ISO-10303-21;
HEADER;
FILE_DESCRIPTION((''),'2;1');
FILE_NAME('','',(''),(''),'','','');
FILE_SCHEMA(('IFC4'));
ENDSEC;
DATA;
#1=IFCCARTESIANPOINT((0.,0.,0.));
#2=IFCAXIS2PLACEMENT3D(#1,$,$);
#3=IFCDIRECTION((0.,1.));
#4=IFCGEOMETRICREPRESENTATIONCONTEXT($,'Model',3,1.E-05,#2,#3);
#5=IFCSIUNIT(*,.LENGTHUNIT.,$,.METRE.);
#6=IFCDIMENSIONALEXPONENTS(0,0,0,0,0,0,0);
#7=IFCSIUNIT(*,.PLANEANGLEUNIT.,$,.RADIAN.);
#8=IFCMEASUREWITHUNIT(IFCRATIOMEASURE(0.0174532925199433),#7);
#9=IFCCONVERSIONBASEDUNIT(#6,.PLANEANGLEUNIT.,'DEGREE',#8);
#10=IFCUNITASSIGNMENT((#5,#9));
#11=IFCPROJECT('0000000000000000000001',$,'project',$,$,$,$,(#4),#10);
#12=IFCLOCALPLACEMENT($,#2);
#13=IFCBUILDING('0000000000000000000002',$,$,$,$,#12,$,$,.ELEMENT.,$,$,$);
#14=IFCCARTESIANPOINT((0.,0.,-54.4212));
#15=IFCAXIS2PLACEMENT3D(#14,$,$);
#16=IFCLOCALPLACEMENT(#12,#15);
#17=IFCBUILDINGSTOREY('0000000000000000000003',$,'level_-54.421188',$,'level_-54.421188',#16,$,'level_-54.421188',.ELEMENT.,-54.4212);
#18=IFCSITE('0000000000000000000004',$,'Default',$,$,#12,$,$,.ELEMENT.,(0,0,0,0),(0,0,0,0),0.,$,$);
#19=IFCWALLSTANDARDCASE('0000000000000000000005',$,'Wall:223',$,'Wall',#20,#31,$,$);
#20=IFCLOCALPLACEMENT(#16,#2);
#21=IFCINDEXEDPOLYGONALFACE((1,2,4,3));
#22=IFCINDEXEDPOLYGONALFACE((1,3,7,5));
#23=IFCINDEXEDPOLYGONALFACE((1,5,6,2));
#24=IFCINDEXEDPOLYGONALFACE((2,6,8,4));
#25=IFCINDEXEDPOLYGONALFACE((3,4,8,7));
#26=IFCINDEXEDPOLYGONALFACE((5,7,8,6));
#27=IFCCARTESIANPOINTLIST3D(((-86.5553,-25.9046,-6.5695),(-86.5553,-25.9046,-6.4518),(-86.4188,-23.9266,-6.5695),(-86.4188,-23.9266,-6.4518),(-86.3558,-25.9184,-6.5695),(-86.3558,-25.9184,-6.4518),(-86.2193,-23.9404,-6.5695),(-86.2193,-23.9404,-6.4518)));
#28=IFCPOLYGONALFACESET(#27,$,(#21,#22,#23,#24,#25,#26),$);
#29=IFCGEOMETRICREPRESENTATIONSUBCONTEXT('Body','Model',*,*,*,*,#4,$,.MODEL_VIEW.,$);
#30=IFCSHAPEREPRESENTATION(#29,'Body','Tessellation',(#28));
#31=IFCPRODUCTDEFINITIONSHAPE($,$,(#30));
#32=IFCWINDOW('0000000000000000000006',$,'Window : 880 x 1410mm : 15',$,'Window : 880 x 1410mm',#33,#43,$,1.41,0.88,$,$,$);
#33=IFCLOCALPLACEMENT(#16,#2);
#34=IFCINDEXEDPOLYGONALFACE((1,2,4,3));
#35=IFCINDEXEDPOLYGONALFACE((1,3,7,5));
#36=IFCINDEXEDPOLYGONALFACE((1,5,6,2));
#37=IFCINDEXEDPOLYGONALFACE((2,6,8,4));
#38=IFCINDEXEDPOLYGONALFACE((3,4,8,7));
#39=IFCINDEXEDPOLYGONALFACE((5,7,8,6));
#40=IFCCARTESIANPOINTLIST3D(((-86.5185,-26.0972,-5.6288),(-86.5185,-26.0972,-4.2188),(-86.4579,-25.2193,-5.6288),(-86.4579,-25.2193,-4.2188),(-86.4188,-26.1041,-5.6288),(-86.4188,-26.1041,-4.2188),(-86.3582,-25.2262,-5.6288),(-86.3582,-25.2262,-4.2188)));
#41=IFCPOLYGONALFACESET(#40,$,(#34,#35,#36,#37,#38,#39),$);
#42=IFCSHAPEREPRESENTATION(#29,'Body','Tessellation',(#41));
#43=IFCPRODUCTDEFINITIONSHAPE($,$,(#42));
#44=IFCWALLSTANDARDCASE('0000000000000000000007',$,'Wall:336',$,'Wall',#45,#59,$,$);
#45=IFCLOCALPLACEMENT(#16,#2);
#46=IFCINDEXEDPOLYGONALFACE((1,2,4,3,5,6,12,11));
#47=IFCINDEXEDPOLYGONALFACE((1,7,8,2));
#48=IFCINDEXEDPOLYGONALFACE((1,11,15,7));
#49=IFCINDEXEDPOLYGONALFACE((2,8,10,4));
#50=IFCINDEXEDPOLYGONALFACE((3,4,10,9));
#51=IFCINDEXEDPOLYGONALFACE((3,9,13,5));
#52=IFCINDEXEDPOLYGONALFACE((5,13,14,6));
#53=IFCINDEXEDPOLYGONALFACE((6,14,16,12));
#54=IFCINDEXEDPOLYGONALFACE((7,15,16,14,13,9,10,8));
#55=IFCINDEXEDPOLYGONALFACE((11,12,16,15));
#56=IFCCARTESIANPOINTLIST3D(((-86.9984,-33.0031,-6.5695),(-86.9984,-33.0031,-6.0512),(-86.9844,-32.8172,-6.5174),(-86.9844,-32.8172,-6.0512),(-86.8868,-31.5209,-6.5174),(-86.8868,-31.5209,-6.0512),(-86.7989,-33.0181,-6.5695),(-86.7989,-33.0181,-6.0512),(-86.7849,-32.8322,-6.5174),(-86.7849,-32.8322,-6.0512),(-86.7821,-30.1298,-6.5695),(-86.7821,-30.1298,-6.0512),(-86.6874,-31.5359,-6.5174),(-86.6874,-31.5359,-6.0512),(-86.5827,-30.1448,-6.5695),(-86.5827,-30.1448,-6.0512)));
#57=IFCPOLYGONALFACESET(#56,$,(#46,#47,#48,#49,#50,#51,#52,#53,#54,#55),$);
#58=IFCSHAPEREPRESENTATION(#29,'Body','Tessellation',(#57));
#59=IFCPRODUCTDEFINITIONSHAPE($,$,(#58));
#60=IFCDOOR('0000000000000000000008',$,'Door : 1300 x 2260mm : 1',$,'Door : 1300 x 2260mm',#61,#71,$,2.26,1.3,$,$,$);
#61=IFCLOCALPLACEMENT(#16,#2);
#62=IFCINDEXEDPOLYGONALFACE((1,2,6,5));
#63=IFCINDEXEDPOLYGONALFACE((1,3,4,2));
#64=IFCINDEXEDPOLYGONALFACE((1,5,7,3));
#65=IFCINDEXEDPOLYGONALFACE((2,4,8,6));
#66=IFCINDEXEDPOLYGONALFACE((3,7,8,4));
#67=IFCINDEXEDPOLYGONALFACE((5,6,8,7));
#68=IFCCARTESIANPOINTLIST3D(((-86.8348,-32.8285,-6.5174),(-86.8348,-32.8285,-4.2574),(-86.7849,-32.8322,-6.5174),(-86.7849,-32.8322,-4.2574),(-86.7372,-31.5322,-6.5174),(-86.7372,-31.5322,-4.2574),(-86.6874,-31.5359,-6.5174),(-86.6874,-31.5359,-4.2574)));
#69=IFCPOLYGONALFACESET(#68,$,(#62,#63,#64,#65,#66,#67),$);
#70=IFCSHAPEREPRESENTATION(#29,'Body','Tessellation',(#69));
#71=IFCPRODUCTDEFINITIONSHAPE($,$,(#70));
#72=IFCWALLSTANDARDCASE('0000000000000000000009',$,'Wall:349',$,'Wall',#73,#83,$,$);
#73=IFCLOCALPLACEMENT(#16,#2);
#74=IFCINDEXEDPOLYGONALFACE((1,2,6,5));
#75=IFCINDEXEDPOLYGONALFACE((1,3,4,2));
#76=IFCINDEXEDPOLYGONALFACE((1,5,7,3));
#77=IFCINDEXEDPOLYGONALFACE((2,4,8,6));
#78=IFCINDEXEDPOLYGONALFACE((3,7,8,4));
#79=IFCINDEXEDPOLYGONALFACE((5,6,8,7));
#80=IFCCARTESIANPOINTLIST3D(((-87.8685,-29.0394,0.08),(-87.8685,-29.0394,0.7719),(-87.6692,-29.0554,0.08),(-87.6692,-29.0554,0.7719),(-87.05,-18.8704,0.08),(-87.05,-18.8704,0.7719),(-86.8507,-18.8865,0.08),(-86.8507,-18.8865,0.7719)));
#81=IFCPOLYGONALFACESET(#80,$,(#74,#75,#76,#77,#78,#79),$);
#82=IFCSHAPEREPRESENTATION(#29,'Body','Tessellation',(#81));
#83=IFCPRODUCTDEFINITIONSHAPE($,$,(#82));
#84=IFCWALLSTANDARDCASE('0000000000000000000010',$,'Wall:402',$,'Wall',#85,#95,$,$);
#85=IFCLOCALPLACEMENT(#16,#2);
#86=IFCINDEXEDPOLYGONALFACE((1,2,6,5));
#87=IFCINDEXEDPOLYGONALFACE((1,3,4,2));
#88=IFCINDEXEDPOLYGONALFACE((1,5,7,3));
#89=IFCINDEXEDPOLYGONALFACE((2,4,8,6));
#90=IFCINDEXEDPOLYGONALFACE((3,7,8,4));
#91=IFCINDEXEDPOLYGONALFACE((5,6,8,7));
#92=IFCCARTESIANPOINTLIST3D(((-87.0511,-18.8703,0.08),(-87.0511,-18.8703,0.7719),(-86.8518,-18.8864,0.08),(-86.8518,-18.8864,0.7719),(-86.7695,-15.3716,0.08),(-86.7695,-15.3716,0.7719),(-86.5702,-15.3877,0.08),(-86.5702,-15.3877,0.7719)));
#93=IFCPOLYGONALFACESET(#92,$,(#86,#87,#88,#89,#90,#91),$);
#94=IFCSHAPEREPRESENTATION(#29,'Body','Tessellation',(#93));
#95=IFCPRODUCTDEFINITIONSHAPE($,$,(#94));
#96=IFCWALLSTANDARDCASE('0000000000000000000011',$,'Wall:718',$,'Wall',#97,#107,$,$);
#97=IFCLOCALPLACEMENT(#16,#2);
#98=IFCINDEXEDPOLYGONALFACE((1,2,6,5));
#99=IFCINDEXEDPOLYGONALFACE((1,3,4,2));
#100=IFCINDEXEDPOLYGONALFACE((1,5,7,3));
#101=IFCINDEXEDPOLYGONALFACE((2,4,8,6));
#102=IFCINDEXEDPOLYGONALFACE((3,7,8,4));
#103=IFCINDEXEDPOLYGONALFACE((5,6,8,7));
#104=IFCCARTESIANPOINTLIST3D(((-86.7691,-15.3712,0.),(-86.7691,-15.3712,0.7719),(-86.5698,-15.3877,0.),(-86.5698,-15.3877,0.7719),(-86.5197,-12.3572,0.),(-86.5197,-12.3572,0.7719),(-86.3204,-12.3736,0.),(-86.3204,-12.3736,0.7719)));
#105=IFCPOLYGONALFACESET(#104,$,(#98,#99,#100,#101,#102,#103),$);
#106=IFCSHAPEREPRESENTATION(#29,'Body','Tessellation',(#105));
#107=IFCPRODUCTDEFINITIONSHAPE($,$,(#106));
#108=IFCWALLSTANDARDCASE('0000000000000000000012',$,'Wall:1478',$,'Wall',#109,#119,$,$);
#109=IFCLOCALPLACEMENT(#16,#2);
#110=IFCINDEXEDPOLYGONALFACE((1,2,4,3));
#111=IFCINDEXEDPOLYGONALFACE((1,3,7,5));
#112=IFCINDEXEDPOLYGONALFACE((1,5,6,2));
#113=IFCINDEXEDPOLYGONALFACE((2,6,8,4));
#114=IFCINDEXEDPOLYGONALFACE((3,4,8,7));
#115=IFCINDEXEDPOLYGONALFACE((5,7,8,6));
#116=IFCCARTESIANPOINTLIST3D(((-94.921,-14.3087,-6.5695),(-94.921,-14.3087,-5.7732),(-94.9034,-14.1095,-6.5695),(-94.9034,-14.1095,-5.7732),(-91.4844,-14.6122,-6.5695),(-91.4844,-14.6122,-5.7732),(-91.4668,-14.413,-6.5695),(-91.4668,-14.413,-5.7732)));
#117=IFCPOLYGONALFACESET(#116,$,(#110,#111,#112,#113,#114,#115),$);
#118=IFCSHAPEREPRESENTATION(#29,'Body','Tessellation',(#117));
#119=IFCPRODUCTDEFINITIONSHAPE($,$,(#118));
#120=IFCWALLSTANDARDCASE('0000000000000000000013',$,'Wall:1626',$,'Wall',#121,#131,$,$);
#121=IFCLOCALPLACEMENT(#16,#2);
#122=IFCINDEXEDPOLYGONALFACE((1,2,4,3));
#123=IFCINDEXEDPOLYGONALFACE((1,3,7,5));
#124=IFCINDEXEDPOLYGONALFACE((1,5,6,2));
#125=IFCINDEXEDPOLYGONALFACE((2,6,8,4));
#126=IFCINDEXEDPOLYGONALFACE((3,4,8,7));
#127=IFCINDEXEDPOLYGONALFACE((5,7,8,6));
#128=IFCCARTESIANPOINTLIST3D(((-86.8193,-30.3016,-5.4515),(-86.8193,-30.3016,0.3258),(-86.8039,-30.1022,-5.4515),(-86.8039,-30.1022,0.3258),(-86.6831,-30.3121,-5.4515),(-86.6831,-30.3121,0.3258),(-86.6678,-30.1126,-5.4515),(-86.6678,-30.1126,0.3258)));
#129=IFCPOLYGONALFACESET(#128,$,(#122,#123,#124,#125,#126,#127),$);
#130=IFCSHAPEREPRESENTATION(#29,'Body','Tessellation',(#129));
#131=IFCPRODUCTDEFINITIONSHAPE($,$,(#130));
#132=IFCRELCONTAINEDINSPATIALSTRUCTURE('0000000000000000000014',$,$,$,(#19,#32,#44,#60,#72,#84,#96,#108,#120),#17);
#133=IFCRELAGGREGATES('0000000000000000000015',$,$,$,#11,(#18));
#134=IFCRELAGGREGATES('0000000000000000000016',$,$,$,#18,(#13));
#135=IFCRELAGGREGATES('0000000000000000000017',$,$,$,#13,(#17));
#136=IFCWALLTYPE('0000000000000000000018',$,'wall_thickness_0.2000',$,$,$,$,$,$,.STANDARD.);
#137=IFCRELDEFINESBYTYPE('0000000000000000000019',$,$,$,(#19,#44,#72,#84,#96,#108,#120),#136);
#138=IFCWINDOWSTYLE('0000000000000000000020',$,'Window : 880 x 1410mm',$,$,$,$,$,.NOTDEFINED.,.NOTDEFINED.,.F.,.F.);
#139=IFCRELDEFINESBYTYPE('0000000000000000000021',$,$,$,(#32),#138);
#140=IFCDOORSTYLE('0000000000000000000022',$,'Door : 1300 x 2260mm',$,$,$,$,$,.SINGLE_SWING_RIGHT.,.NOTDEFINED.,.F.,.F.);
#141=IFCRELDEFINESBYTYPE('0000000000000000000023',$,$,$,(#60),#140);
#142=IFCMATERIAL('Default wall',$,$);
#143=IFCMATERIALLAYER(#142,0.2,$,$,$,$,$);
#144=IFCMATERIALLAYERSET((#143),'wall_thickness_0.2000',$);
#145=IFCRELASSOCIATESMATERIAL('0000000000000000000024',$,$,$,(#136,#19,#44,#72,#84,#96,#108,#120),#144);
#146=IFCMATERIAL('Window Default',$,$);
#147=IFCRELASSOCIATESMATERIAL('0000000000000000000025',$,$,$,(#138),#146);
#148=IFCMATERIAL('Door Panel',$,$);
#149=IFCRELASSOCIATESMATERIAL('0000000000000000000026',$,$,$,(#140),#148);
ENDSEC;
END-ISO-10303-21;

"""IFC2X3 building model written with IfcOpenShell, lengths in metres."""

from ifc_helpers import new_model, entity, si_unit, converted_unit, direction, frame, frame_2d, origin, origin_2d_with_axis, place, context, subcontext, project, spatial, polyline, rectangle, outline, extrude, source, transform, mapped, material, layer, layer_set, layer_usage, type_object, type_shapes, element, fill, save


model = new_model("IFC2X3")

# Units and contexts
model_context = context("Model", 3, precision=1e-05, world=origin(), true_north=direction((0.0, 1.0)))
body_context = subcontext(model_context, "Body", "Model", "MODEL_VIEW")
ifc_project = project(units=[si_unit("LENGTHUNIT", "METRE"), converted_unit("PLANEANGLEUNIT", "DEGREE", entity("IfcRatioMeasure", 0.0174532925199433), si_unit("PLANEANGLEUNIT", "RADIAN"), dimensions=[0, 0, 0, 0, 0, 0, 0])], contexts=[model_context])

# Site, building, storey
placement_1 = place(None, origin())
site = spatial("IfcSite", under=ifc_project, at=placement_1, Name="Default", CompositionType="ELEMENT", RefLatitude=(0, 0, 0, 0), RefLongitude=(0, 0, 0, 0), RefElevation=0.0)
building = spatial("IfcBuilding", under=site, at=placement_1, CompositionType="ELEMENT")
storey_placement = place(placement_1, frame((0.0, 0.0, -54.4212)))
storey = spatial("IfcBuildingStorey", under=building, at=storey_placement, Name="level_-54.421188", ObjectType="level_-54.421188", LongName="level_-54.421188", CompositionType="ELEMENT", Elevation=-54.4212)

# Wall, opening, window
ifc_material_1 = material(Name="Default wall")
ifc_layer = layer(ifc_material_1, 0.2)
ifc_layer_set = layer_set([ifc_layer], Name="wall_thickness_0.2000")
ifc_layer_usage = layer_usage(ifc_layer_set, "AXIS2", "POSITIVE", -0.1)
wall_type = type_object("IfcWallType", Name="wall_thickness_0.2000", PredefinedType="STANDARD", material=ifc_layer_set)
placement_2 = place(placement_1, frame((0.0, 0.0, -60.9907)))
wall_1_placement = place(placement_2, frame((-86.319, -23.9335, 0.0), z_axis=(0.0, 0.0, 1.0), x_axis=(-0.068864, -0.997626, 0.0)))
wall_1 = element("IfcWallStandardCase", 1, at=wall_1_placement, inside=storey, type_object=wall_type, material=ifc_layer_usage, Name="Wall:223", ObjectType="Wall", context=body_context, shape_type="SweptSolid", body=[
    extrude(outline(polyline([(1.9827, -0.1), (1.9827, 0.1), (0.0, 0.1), (0.0, -0.1), (1.9827, -0.1)])), origin(), (0.0, 0.0, 1.0), 0.1176),
])
opening_1_placement = place(wall_1_placement, frame((1.2923, -0.1, 0.9407)))
opening_1 = element("IfcOpeningElement", 2, at=opening_1_placement, cuts=wall_1, ObjectType="Opening", context=body_context, shape_type="SweptSolid", body=[
    extrude(rectangle(XDim=0.88, YDim=1.41, at=frame_2d((0.705, 0.44), x_axis=(0.0, 1.0))), frame((0.0, 0.0, 0.0), z_axis=(0.0, 1.0, 0.0), x_axis=(0.0, 0.0, 1.0)), (0.0, 0.0, 1.0), 0.2),
])
ifc_material_2 = material(Name="Window Default")
window_style_1 = type_object("IfcWindowStyle", Name="Window : 880 x 1410mm", ConstructionType="NOTDEFINED", OperationType="NOTDEFINED", ParameterTakesPrecedence=False, Sizeable=False, material=ifc_material_2)
shared_shape_1 = source(origin(), body_context, "Body", "SweptSolid", [
    extrude(rectangle(XDim=0.1, YDim=0.88, at=origin_2d_with_axis()), frame((0.44, 0.1, 0.0), z_axis=(0.0, 0.0, 1.0), x_axis=(0.0, 1.0, 0.0)), (0.0, 0.0, 1.0), 1.41),
])
type_shapes(window_style_1, [shared_shape_1])
window_1_placement = place(opening_1_placement, origin())
window_1 = element("IfcWindow", 3, at=window_1_placement, inside=storey, type_object=window_style_1, Name="Window : 880 x 1410mm : 15", ObjectType="Window : 880 x 1410mm", OverallHeight=1.41, OverallWidth=0.88, context=body_context, shape_type="MappedRepresentation", body=[
    mapped(shared_shape_1, transform((0.0, 0.0, 0.0), scale=1.0)),
])
fill(opening_1, window_1)

# Wall, opening, door
placement_3 = place(placement_1, frame((0.0, 0.0, -60.9907)))
wall_2_placement = place(placement_3, frame((-86.6824, -30.1373, 0.0), z_axis=(0.0, 0.0, 1.0), x_axis=(-0.075052, -0.99718, 0.0)))
wall_2 = element("IfcWallStandardCase", 4, at=wall_2_placement, inside=storey, type_object=wall_type, material=ifc_layer_usage, Name="Wall:336", ObjectType="Wall", context=body_context, shape_type="SweptSolid", body=[
    extrude(outline(polyline([(2.8814, -0.1), (2.8814, 0.1), (0.0, 0.1), (0.0, -0.1), (2.8814, -0.1)])), origin(), (0.0, 0.0, 1.0), 0.5182),
])
opening_2_placement = place(wall_2_placement, frame((1.395, -0.1, 0.052)))
opening_2 = element("IfcOpeningElement", 5, at=opening_2_placement, cuts=wall_2, ObjectType="Opening", context=body_context, shape_type="SweptSolid", body=[
    extrude(rectangle(XDim=1.3, YDim=2.26, at=frame_2d((1.13, 0.65), x_axis=(0.0, 1.0))), frame((0.0, 0.0, 0.0), z_axis=(0.0, 1.0, 0.0), x_axis=(0.0, 0.0, 1.0)), (0.0, 0.0, 1.0), 0.2),
])
ifc_material_3 = material(Name="Door Panel")
door_style = type_object("IfcDoorStyle", Name="Door : 1300 x 2260mm", ConstructionType="NOTDEFINED", OperationType="SINGLE_SWING_RIGHT", ParameterTakesPrecedence=False, Sizeable=False, material=ifc_material_3)
shared_shape_2 = source(origin(), body_context, "Body", "SweptSolid", [
    extrude(rectangle(XDim=0.05, YDim=1.3, at=origin_2d_with_axis()), frame((0.65, 0.175, 0.0), z_axis=(0.0, 0.0, 1.0), x_axis=(0.0, 1.0, 0.0)), (0.0, 0.0, 1.0), 2.26),
])
type_shapes(door_style, [shared_shape_2])
door_placement = place(opening_2_placement, origin())
door = element("IfcDoor", 6, at=door_placement, inside=storey, type_object=door_style, Name="Door : 1300 x 2260mm : 1", ObjectType="Door : 1300 x 2260mm", OverallHeight=2.26, OverallWidth=1.3, context=body_context, shape_type="MappedRepresentation", body=[
    mapped(shared_shape_2, transform((0.0, 0.0, 0.0), scale=1.0)),
])
fill(opening_2, door)

# Walls
placement_4 = place(placement_1, frame((0.0, 0.0, -54.3412)))
wall_3_placement = place(placement_4, frame((-87.7688, -29.0474, 0.0), z_axis=(0.0, 0.0, 1.0), x_axis=(0.080227, 0.996777, 0.0)))
element("IfcWallStandardCase", 7, at=wall_3_placement, inside=storey, type_object=wall_type, material=ifc_layer_usage, Name="Wall:349", ObjectType="Wall", context=body_context, shape_type="SweptSolid", body=[
    extrude(outline(polyline([(10.2018, -0.1), (10.2018, 0.1), (0.0, 0.1), (0.0, -0.1), (10.2018, -0.1)])), origin(), (0.0, 0.0, 1.0), 0.692),
])
placement_5 = place(placement_1, frame((0.0, 0.0, -54.3412)))
wall_4_placement = place(placement_5, frame((-86.9515, -18.8784, 0.0), z_axis=(0.0, 0.0, 1.0), x_axis=(0.080232, 0.996776, 0.0)))
element("IfcWallStandardCase", 8, at=wall_4_placement, inside=storey, type_object=wall_type, material=ifc_layer_usage, Name="Wall:402", ObjectType="Wall", context=body_context, shape_type="SweptSolid", body=[
    extrude(outline(polyline([(3.51, -0.1), (3.51, 0.1), (0.0, 0.1), (0.0, -0.1), (3.51, -0.1)])), origin(), (0.0, 0.0, 1.0), 0.692),
])
wall_5_placement = place(storey_placement, frame((-86.6694, -15.3795, 0.0), z_axis=(0.0, 0.0, 1.0), x_axis=(0.082445, 0.996596, 0.0)))
element("IfcWallStandardCase", 9, at=wall_5_placement, inside=storey, type_object=wall_type, material=ifc_layer_usage, Name="Wall:718", ObjectType="Wall", context=body_context, shape_type="SweptSolid", body=[
    extrude(outline(polyline([(3.0244, -0.1), (3.0244, 0.1), (0.0, 0.1), (0.0, -0.1), (3.0244, -0.1)])), origin(), (0.0, 0.0, 1.0), 0.7719),
])
placement_6 = place(placement_1, frame((0.0, 0.0, -60.9907)))
wall_6_placement = place(placement_6, frame((-94.9122, -14.2091, 0.0), z_axis=(0.0, 0.0, 1.0), x_axis=(0.996122, -0.087985, 0.0)))
element("IfcWallStandardCase", 10, at=wall_6_placement, inside=storey, type_object=wall_type, material=ifc_layer_usage, Name="Wall:1478", ObjectType="Wall", context=body_context, shape_type="SweptSolid", body=[
    extrude(outline(polyline([(3.45, -0.1), (3.45, 0.1), (0.0, 0.1), (0.0, -0.1), (3.45, -0.1)])), origin(), (0.0, 0.0, 1.0), 0.7963),
])
placement_7 = place(placement_1, frame((0.0, 0.0, -59.8727)))
wall_7_placement = place(placement_7, frame((-86.6754, -30.2123, 0.0), z_axis=(0.0, 0.0, 1.0), x_axis=(-0.997055, 0.076687, 0.0)))
element("IfcWallStandardCase", 11, at=wall_7_placement, inside=storey, type_object=wall_type, material=ifc_layer_usage, Name="Wall:1626", ObjectType="Wall", context=body_context, shape_type="SweptSolid", body=[
    extrude(outline(polyline([(0.1366, -0.1), (0.1366, 0.1), (0.0, 0.1), (0.0, -0.1), (0.1366, -0.1)])), origin(), (0.0, 0.0, 1.0), 5.7772),
])

save(model, "model.ifc")
